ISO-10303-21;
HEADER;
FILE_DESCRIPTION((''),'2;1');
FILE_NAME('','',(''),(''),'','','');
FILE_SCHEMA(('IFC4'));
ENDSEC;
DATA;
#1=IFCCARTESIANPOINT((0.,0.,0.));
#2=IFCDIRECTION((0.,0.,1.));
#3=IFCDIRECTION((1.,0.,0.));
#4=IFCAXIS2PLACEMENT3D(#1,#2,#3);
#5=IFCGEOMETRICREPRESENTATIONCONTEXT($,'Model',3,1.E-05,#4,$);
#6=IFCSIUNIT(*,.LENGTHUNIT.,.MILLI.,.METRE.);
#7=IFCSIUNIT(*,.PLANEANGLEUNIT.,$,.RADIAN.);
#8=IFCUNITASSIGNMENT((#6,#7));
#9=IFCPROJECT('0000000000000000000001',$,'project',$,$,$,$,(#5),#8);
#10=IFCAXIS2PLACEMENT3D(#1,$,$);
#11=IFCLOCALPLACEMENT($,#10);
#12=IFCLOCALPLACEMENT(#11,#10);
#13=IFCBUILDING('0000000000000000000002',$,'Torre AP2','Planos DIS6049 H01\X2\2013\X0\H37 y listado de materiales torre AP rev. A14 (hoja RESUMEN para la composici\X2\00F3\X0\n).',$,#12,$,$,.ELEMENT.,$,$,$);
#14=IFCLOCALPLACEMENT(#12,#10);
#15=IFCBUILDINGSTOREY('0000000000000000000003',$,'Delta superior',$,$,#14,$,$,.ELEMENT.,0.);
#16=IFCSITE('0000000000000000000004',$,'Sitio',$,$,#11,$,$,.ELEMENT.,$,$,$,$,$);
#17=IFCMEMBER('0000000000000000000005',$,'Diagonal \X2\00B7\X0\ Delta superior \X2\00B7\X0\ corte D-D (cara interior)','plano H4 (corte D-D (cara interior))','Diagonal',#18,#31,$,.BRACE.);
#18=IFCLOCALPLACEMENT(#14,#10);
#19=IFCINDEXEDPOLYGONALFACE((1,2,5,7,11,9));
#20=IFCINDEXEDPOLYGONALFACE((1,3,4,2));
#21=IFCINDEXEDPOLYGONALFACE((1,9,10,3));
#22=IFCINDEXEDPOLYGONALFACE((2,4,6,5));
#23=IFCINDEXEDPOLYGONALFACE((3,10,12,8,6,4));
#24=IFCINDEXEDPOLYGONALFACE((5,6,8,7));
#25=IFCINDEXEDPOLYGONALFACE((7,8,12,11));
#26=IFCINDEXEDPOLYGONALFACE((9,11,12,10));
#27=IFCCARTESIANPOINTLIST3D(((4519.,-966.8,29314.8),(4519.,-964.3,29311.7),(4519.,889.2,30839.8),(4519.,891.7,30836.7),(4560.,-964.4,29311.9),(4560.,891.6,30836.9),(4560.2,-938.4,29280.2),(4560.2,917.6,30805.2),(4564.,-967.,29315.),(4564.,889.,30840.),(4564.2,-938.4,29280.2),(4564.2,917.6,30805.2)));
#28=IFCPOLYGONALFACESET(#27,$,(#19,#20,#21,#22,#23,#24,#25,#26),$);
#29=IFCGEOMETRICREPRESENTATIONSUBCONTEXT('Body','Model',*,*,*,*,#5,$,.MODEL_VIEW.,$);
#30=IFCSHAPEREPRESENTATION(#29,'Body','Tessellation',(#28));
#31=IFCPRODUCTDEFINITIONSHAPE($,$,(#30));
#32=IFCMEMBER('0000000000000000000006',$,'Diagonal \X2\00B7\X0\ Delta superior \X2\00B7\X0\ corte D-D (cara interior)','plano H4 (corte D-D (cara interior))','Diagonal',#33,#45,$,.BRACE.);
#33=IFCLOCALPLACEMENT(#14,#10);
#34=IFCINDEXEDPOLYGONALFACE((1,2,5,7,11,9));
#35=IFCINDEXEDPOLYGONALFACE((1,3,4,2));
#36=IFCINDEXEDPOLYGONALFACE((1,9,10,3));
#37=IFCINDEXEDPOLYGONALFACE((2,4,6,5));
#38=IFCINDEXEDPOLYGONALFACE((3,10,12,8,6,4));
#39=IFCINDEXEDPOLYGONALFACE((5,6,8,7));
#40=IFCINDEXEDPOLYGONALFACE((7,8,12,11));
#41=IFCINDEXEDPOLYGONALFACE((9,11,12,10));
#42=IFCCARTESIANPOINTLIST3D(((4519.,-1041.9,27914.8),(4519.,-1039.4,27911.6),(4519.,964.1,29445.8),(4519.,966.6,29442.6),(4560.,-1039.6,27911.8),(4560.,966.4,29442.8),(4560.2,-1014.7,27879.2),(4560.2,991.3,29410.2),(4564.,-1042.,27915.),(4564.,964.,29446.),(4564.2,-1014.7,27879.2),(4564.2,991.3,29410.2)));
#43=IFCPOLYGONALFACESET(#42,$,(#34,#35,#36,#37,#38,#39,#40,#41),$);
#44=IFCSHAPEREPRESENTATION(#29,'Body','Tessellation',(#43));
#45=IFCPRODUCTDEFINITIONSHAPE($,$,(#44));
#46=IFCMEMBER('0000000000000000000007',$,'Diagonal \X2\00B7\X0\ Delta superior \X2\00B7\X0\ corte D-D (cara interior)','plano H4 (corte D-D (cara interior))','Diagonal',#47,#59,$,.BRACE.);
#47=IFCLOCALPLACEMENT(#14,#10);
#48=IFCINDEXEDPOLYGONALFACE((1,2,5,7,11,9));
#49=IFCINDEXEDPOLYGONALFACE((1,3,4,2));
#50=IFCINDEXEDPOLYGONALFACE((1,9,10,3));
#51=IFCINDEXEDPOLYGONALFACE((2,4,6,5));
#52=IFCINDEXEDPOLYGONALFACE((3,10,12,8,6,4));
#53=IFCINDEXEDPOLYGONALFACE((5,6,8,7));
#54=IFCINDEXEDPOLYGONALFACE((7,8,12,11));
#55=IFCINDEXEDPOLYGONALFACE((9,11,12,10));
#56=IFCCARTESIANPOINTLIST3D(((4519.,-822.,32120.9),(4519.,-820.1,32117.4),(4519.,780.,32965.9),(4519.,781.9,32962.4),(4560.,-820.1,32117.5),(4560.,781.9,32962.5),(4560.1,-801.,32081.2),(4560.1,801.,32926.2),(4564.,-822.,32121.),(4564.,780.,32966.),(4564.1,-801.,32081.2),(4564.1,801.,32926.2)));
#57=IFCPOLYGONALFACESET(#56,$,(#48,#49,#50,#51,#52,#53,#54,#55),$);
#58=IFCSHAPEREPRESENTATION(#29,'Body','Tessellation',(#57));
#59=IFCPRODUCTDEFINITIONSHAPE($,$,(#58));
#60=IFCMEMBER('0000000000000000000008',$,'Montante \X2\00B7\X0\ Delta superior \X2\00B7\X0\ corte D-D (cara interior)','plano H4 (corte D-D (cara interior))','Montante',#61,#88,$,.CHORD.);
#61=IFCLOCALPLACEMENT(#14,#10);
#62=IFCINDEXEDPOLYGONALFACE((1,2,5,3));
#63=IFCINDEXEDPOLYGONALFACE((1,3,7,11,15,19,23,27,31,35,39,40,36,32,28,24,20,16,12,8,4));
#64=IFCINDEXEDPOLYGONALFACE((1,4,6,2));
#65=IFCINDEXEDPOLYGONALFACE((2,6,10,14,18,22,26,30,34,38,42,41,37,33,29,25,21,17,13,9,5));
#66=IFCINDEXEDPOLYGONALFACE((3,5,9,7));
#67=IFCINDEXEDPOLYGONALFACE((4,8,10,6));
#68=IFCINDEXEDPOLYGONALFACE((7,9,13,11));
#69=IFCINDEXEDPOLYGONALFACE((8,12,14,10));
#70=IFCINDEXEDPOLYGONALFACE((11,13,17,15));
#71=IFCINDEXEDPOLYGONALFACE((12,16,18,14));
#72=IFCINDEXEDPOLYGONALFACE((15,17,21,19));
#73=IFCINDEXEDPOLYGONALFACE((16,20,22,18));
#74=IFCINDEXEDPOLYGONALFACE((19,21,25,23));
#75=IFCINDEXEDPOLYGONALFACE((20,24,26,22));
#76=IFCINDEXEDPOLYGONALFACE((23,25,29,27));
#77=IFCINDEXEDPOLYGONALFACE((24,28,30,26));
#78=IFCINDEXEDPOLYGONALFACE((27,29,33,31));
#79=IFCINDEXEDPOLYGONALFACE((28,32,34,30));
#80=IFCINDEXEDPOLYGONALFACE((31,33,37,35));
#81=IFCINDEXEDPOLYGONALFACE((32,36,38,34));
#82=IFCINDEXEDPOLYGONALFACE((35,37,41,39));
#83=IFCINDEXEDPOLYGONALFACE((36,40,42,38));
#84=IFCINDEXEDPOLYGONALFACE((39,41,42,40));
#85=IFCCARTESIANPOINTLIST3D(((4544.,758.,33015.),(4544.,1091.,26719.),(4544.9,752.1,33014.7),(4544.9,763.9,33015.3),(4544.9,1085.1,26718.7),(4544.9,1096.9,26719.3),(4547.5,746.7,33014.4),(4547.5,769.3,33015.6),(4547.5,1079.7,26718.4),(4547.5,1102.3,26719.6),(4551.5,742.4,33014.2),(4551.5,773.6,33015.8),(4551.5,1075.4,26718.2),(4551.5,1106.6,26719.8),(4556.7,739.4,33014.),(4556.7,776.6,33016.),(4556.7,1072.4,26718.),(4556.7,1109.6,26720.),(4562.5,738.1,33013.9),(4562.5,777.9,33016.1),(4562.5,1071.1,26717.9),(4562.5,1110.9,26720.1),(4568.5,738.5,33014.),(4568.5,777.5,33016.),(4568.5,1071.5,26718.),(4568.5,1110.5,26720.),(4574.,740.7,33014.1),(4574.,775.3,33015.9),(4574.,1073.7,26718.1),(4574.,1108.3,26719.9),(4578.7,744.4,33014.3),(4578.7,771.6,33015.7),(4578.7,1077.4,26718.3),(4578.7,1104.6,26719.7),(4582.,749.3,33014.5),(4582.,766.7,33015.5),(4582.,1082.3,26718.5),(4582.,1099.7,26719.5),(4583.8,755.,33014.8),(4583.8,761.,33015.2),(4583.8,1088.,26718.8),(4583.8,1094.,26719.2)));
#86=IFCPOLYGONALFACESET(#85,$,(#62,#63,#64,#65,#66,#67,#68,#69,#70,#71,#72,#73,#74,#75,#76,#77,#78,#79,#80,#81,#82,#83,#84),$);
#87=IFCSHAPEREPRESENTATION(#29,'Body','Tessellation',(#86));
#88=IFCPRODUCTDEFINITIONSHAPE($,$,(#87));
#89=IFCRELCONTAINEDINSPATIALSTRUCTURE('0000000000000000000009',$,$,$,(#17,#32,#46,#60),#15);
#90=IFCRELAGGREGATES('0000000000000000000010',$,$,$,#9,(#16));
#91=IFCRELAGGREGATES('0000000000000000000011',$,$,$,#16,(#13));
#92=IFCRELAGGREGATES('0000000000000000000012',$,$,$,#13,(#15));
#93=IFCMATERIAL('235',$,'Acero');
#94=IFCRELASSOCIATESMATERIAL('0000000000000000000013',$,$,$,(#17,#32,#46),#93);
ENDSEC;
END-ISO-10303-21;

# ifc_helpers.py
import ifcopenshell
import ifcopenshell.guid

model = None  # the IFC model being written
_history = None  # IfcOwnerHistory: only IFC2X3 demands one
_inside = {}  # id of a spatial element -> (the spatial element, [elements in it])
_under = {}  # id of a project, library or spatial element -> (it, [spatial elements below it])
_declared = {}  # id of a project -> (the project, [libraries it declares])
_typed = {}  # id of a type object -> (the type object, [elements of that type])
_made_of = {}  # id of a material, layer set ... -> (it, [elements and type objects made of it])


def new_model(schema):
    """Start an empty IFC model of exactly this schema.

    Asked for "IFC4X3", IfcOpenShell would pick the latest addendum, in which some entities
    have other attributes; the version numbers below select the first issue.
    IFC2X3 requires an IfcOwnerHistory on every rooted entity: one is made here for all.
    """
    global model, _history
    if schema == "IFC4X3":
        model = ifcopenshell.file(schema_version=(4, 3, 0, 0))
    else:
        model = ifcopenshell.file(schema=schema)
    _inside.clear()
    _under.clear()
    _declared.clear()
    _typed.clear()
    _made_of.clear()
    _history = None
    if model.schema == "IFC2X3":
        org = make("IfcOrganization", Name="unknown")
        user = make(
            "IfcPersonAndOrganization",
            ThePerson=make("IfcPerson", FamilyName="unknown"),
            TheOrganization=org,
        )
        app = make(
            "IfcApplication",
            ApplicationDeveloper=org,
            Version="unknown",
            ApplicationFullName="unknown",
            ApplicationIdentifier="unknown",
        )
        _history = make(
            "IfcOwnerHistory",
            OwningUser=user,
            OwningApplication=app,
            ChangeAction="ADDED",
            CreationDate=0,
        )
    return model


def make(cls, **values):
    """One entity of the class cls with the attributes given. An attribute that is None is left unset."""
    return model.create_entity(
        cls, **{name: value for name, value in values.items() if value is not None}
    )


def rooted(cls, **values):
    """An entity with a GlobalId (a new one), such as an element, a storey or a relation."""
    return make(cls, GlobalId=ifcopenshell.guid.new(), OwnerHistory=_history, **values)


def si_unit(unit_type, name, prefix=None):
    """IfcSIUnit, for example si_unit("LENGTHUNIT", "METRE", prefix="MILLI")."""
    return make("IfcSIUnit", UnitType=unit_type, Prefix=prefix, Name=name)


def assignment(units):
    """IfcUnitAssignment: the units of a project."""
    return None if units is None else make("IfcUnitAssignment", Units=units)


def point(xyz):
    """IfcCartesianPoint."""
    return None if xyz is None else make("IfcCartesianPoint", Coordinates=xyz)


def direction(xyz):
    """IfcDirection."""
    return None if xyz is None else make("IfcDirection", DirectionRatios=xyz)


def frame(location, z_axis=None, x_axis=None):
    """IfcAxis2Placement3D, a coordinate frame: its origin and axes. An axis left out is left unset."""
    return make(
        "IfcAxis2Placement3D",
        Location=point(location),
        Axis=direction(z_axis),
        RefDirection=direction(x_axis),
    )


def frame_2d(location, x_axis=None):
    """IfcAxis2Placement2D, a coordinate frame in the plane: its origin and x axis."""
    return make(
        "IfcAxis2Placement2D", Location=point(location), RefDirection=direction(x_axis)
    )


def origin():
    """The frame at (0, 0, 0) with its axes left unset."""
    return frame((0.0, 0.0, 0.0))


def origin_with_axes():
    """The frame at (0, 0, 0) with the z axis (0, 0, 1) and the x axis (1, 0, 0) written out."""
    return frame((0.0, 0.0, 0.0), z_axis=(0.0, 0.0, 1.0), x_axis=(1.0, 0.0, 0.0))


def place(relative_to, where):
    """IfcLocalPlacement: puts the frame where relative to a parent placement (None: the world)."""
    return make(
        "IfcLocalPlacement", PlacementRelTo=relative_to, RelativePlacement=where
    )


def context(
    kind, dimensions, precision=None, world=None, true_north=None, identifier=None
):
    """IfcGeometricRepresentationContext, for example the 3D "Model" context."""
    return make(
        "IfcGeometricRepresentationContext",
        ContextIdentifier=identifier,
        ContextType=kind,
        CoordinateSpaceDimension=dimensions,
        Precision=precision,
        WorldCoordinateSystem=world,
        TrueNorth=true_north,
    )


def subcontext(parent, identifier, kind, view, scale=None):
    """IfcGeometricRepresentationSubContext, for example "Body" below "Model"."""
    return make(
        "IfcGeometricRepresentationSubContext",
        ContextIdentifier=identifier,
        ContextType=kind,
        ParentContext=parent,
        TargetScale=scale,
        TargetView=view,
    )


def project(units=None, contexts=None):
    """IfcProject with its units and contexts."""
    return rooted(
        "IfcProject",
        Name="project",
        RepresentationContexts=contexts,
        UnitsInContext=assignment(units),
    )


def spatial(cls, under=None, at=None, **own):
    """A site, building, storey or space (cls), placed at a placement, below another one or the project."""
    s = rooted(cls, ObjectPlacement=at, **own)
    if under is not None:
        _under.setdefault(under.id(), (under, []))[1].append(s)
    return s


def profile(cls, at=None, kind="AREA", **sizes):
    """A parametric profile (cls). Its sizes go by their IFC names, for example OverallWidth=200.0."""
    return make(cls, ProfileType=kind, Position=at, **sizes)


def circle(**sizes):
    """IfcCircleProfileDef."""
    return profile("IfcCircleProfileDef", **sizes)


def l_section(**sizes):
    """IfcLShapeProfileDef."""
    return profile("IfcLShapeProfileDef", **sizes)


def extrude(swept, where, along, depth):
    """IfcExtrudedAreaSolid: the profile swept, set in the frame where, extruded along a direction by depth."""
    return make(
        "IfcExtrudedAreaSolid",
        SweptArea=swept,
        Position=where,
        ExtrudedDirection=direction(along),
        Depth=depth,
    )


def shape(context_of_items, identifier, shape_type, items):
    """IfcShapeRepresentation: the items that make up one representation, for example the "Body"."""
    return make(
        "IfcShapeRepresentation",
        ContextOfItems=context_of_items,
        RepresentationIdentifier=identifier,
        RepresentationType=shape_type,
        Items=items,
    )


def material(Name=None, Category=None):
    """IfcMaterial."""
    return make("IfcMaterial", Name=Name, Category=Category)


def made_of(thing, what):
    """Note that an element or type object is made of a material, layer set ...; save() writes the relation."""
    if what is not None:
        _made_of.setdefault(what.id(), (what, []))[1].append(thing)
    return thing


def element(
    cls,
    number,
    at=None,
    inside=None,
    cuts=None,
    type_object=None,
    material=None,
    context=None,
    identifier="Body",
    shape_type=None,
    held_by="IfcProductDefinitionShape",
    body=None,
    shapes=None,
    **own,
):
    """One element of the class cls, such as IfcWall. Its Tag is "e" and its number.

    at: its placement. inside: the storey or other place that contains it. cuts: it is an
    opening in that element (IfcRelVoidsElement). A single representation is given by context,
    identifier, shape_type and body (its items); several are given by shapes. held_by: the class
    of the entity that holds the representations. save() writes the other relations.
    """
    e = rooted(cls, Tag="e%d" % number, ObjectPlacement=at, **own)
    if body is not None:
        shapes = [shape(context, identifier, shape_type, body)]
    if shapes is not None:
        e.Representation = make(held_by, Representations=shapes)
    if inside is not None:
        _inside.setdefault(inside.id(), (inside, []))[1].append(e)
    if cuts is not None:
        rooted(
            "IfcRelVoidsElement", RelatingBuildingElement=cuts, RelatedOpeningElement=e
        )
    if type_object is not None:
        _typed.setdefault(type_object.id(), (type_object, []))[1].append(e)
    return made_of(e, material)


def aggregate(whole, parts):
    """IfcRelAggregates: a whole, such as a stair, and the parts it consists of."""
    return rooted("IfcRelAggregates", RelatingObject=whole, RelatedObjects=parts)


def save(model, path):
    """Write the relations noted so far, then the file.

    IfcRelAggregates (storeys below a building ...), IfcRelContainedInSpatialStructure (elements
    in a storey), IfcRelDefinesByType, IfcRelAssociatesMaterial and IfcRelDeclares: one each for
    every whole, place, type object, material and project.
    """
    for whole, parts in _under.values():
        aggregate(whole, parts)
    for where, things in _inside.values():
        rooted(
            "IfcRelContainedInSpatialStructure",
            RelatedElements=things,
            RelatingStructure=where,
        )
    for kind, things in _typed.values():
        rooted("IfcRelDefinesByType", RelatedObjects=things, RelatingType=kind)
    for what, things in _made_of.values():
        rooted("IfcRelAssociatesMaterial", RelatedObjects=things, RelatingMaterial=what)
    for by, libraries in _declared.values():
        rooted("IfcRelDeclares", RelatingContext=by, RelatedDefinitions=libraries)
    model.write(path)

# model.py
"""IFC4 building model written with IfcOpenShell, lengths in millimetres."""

from ifc_helpers import new_model, si_unit, frame, frame_2d, origin, origin_with_axes, place, context, subcontext, project, spatial, circle, l_section, extrude, material, element, save


model = new_model("IFC4")

# Units and contexts
model_context = context("Model", 3, precision=1e-05, world=origin_with_axes())
body_context = subcontext(model_context, "Body", "Model", "MODEL_VIEW")
ifc_project = project(units=[si_unit("LENGTHUNIT", "METRE", prefix="MILLI"), si_unit("PLANEANGLEUNIT", "RADIAN")], contexts=[model_context])

# Site, building, storey
site_placement = place(None, origin())
site = spatial("IfcSite", under=ifc_project, at=site_placement, Name="Sitio", CompositionType="ELEMENT")
building_placement = place(site_placement, origin())
building = spatial("IfcBuilding", under=site, at=building_placement, Name="Torre AP2", Description="Planos DIS6049 H01–H37 y listado de materiales torre AP rev. A14 (hoja RESUMEN para la composición).", CompositionType="ELEMENT")
storey_placement = place(building_placement, origin())
storey = spatial("IfcBuildingStorey", under=building, at=storey_placement, Name="Delta superior", CompositionType="ELEMENT", Elevation=0.0)

# Members
ifc_material_1 = material(Name="235", Category="Acero")
member_1_placement = place(storey_placement, frame((4564.0, 889.0, 30840.0), z_axis=(0.0, -0.772639, -0.634846), x_axis=(-0.999985, 0.003444, -0.004191)))
element("IfcMember", 1, at=member_1_placement, inside=storey, material=ifc_material_1, Name="Diagonal · Delta superior · corte D-D (cara interior)", Description="plano H4 (corte D-D (cara interior))", ObjectType="Diagonal", PredefinedType="BRACE", context=body_context, shape_type="SweptSolid", body=[
    extrude(l_section(Depth=45.0, Width=45.0, Thickness=4.0, at=frame_2d((22.5, 22.5))), None, (0.0, 0.0, 1.0), 2402.2),
])
member_2_placement = place(storey_placement, frame((4564.0, 964.0, 29446.0), z_axis=(0.0, -0.794931, -0.6067), x_axis=(-0.999987, 0.003145, -0.004121)))
element("IfcMember", 2, at=member_2_placement, inside=storey, material=ifc_material_1, Name="Diagonal · Delta superior · corte D-D (cara interior)", Description="plano H4 (corte D-D (cara interior))", ObjectType="Diagonal", PredefinedType="BRACE", context=body_context, shape_type="SweptSolid", body=[
    extrude(l_section(Depth=45.0, Width=45.0, Thickness=4.0, at=frame_2d((22.5, 22.5))), None, (0.0, 0.0, 1.0), 2523.5),
])
member_3_placement = place(storey_placement, frame((4564.0, 780.0, 32966.0), z_axis=(0.0, -0.884499, -0.466543), x_axis=(-0.999998, 0.001002, -0.001899)))
element("IfcMember", 3, at=member_3_placement, inside=storey, material=ifc_material_1, Name="Diagonal · Delta superior · corte D-D (cara interior)", Description="plano H4 (corte D-D (cara interior))", ObjectType="Diagonal", PredefinedType="BRACE", context=body_context, shape_type="SweptSolid", body=[
    extrude(l_section(Depth=45.0, Width=45.0, Thickness=4.0, at=frame_2d((22.5, 22.5))), None, (0.0, 0.0, 1.0), 1811.2),
])
member_4_placement = place(storey_placement, frame((4564.0, 1091.0, 26719.0), z_axis=(0.0, -0.052817, 0.998604), x_axis=(-1.0, 0.0, 0.0)))
element("IfcMember", 4, at=member_4_placement, inside=storey, Name="Montante · Delta superior · corte D-D (cara interior)", Description="plano H4 (corte D-D (cara interior))", ObjectType="Montante", PredefinedType="CHORD", context=body_context, shape_type="SweptSolid", body=[
    extrude(circle(Radius=20.0), None, (0.0, 0.0, 1.0), 6304.8),
])

save(model, "model.ifc")
